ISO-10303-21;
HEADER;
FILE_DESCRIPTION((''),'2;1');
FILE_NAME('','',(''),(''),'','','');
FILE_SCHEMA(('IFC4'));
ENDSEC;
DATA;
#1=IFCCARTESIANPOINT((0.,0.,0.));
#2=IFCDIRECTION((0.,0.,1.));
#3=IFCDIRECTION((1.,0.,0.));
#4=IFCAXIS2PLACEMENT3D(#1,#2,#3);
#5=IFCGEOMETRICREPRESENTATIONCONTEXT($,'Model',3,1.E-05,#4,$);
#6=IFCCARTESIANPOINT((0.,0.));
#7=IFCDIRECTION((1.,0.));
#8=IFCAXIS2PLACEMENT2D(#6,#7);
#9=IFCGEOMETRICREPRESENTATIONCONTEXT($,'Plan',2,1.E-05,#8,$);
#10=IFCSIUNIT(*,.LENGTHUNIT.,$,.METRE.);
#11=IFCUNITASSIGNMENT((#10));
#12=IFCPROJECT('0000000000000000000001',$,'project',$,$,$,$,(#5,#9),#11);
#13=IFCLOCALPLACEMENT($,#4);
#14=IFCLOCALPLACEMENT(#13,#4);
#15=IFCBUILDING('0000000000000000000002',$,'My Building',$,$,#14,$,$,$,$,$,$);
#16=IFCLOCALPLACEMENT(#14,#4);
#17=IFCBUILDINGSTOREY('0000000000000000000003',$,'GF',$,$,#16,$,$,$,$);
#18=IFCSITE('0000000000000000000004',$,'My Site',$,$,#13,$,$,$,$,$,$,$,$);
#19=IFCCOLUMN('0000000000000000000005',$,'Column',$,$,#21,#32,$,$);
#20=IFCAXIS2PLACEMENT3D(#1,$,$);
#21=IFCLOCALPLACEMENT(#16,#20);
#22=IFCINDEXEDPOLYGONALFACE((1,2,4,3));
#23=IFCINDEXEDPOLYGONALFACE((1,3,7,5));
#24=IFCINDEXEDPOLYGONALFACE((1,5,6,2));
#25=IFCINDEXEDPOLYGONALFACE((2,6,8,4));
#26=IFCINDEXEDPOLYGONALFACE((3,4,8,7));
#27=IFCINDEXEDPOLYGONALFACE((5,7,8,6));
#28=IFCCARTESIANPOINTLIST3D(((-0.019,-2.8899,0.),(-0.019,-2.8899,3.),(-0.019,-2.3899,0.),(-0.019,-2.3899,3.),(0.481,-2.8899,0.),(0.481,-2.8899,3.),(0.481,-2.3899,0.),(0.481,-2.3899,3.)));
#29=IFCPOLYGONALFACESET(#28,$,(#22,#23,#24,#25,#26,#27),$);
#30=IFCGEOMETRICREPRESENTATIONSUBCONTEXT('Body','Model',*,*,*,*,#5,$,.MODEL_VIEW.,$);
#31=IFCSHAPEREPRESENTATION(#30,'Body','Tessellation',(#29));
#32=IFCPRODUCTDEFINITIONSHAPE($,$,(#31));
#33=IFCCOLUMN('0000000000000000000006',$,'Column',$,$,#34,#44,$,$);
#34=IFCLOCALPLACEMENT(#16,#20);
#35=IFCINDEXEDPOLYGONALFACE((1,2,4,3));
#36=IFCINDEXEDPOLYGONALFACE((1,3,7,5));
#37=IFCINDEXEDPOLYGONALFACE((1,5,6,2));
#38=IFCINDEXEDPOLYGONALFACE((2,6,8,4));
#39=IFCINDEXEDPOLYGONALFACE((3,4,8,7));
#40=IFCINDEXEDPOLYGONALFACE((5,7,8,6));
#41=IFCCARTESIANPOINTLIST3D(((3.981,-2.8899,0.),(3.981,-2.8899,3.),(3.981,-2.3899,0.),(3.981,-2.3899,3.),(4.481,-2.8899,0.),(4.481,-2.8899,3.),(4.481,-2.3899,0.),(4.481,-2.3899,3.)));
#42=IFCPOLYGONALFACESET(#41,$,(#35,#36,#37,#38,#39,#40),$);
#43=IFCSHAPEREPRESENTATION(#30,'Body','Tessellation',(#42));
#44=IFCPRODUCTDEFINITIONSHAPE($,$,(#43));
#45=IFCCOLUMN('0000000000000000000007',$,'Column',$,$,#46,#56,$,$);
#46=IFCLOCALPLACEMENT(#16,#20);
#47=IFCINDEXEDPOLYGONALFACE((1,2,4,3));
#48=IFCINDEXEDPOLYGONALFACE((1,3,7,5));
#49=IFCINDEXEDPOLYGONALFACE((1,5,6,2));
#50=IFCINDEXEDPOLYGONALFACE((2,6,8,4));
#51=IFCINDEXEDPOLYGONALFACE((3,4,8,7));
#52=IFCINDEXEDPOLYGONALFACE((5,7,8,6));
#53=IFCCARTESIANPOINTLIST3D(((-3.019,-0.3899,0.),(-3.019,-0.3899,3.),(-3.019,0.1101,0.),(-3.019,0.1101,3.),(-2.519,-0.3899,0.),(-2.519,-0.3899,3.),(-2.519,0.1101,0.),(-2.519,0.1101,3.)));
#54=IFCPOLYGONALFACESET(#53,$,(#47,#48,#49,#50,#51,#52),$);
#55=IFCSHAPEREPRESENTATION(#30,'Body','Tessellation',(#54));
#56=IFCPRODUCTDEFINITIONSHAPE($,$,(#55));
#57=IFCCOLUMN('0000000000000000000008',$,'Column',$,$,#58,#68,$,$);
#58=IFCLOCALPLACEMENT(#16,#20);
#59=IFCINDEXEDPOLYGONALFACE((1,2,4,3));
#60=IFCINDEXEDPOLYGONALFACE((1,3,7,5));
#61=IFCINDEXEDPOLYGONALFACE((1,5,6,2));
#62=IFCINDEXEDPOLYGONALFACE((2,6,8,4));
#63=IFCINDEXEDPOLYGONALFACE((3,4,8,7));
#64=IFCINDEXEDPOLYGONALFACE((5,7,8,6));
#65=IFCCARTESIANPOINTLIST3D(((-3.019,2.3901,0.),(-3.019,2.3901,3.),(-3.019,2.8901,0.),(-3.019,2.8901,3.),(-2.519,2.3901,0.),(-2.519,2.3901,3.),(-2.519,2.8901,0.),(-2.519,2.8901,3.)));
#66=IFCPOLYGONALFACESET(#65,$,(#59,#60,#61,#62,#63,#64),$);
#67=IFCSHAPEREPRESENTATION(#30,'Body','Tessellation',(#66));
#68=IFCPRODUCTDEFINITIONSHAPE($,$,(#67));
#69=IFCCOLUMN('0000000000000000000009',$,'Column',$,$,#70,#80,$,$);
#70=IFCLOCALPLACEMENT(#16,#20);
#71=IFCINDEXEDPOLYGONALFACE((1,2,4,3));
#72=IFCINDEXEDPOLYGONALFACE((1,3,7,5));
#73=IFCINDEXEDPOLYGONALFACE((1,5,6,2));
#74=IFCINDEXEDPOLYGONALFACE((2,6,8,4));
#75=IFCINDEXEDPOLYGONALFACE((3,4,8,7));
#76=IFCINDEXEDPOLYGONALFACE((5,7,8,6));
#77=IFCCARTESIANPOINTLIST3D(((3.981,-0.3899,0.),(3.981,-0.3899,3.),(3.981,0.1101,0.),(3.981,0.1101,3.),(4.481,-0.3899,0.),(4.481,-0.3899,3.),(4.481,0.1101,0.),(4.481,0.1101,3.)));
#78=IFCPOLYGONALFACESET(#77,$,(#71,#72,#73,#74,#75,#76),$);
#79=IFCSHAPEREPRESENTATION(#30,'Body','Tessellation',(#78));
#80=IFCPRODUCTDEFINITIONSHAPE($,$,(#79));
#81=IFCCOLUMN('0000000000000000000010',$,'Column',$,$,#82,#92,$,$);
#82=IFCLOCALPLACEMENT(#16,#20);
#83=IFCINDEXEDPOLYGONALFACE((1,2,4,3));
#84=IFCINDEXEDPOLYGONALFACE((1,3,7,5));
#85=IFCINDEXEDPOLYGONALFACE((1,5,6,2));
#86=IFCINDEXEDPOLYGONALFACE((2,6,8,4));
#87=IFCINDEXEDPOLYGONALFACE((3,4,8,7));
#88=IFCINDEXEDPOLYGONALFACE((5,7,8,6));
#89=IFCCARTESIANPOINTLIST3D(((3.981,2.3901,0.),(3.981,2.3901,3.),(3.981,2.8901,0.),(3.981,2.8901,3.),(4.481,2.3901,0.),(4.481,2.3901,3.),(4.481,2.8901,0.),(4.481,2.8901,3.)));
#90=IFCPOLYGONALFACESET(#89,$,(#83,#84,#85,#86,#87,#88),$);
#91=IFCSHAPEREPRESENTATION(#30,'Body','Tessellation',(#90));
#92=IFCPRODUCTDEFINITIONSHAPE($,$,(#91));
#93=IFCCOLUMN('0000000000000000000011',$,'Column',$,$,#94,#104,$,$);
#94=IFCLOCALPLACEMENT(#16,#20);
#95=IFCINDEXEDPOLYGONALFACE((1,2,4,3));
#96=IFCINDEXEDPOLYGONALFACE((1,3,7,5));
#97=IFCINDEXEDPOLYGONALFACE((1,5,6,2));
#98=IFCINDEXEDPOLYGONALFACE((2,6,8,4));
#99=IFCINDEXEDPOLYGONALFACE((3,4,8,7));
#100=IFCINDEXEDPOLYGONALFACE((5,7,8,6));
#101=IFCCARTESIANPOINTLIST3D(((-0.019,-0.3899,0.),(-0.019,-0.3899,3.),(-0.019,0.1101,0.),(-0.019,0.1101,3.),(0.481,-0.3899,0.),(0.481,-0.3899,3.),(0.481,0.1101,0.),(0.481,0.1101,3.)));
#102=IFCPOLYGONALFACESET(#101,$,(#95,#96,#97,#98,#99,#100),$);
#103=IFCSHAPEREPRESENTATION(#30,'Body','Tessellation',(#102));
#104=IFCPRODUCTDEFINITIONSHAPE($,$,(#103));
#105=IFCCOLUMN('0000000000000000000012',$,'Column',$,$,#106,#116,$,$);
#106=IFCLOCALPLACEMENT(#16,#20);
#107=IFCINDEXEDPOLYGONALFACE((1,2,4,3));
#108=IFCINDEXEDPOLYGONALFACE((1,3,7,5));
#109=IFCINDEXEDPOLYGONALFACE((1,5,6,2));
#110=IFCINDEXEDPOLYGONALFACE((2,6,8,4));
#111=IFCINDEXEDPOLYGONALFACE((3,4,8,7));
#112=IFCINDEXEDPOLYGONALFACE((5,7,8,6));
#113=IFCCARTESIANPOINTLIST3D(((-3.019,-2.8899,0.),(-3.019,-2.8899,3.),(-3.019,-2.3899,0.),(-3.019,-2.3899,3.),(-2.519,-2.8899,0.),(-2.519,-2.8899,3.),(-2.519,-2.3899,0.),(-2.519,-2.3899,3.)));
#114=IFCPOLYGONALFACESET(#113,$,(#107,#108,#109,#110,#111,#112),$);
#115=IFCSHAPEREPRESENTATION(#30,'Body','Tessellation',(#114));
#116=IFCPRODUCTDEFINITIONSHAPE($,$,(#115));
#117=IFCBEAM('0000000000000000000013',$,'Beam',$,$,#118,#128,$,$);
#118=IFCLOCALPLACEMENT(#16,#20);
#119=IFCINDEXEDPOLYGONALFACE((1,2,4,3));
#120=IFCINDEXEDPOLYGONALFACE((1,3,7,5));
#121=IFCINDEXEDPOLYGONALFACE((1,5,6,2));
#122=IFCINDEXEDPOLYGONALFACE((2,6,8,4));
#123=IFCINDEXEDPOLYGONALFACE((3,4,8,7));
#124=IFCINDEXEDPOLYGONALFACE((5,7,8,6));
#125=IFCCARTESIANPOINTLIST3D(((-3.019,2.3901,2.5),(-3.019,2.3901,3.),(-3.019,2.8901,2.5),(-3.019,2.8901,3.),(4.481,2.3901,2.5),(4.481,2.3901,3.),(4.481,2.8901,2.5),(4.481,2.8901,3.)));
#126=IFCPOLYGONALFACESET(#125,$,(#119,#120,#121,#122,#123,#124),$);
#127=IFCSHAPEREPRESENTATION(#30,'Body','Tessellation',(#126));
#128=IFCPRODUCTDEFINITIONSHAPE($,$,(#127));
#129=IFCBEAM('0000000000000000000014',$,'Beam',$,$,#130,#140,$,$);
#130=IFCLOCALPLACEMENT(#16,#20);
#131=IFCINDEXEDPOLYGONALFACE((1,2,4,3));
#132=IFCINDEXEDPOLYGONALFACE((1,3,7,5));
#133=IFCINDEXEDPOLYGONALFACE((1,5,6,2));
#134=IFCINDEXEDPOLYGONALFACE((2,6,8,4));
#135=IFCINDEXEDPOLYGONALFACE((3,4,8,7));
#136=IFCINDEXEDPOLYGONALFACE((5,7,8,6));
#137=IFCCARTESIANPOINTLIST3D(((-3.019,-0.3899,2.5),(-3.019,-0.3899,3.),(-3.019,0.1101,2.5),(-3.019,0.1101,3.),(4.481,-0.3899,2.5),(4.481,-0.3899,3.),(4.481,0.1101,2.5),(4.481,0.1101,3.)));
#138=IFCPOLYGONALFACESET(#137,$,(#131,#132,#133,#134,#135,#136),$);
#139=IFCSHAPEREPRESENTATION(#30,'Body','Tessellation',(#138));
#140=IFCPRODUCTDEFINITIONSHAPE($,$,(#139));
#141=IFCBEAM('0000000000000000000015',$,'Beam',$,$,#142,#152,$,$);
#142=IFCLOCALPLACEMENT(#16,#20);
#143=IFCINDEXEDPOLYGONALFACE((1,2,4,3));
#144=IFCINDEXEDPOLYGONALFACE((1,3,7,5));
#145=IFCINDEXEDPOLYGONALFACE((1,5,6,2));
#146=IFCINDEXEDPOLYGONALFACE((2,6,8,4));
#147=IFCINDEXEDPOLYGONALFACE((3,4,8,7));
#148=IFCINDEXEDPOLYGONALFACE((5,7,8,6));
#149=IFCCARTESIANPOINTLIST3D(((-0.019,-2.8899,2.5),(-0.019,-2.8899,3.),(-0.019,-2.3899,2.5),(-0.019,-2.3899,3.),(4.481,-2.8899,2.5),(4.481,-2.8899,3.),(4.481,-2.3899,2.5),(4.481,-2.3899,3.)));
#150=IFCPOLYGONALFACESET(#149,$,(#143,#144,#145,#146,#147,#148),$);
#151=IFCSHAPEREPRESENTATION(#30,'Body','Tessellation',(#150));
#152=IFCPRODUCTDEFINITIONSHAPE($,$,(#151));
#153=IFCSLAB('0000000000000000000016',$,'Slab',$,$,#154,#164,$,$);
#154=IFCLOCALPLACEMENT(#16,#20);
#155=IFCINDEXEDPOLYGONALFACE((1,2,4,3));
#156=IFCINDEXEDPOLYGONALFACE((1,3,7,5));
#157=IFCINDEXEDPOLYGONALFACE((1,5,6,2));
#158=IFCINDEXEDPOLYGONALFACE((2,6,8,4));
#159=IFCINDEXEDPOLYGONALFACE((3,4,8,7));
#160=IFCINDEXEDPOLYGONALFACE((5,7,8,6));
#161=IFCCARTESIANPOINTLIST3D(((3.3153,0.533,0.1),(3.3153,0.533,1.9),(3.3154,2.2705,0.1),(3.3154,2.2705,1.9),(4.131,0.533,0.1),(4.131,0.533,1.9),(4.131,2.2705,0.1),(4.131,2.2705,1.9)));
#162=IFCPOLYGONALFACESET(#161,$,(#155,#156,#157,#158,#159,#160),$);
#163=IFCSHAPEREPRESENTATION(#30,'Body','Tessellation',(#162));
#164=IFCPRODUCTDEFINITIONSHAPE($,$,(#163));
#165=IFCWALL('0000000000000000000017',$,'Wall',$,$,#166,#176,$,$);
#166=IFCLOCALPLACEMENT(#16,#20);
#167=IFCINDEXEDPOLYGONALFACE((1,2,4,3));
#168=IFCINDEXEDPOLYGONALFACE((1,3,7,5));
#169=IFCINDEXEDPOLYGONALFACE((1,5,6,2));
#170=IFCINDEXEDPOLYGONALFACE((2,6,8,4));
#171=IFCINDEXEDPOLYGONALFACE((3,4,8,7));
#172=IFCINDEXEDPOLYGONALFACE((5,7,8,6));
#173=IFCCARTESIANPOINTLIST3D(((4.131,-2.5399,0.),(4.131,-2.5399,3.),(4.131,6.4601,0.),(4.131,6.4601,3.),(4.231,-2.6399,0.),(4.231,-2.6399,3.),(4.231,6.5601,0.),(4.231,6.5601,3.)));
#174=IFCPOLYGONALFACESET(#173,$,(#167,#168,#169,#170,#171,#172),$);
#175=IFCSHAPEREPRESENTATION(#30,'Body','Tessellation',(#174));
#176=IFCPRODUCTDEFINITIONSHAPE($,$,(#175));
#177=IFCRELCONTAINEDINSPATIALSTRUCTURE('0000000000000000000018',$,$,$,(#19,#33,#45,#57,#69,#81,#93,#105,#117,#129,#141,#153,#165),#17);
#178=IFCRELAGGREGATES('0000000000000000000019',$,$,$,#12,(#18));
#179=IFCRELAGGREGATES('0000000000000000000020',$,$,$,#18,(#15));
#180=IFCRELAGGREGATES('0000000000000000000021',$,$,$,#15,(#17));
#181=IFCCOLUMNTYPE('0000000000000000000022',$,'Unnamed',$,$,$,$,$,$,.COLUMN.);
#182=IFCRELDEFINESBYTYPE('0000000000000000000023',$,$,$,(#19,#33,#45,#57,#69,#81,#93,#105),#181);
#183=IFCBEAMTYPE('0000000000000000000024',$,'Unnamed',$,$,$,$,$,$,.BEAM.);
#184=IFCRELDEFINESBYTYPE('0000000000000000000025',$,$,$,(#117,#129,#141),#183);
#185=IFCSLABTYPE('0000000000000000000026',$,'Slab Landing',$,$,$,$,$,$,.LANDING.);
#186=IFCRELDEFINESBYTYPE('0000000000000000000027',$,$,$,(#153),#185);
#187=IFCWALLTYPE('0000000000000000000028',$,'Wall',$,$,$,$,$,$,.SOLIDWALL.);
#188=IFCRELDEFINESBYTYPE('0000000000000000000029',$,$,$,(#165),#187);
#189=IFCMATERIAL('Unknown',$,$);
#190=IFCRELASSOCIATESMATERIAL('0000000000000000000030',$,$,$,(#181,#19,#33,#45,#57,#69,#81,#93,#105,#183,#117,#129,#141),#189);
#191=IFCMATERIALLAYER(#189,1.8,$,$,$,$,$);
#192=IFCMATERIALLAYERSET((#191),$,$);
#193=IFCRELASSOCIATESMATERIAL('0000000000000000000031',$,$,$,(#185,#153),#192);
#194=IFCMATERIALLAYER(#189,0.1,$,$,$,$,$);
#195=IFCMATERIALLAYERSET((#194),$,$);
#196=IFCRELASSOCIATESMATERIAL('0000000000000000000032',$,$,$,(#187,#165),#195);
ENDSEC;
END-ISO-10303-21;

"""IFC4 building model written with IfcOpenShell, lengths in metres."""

from ifc_helpers import new_model, si_unit, frame, origin_with_axes, origin_2d_with_axis, place, context, subcontext, project, spatial, line, indexed_curve, rectangle, outline, extrude, material, layer, layer_set, layer_usage, material_profile, profile_set, profile_usage, type_object, element, save


model = new_model("IFC4")

# Units and contexts
model_context = context("Model", 3, precision=1e-05, world=origin_with_axes())
plan_context = context("Plan", 2, precision=1e-05, world=origin_2d_with_axis())
body_context_1 = subcontext(model_context, "Body", "Model", "MODEL_VIEW")
ifc_project = project(units=[si_unit("LENGTHUNIT", "METRE")], contexts=[model_context, plan_context])

# Site, building, storey
site_placement = place(None, origin_with_axes())
site = spatial("IfcSite", under=ifc_project, at=site_placement, Name="My Site")
building_placement = place(site_placement, origin_with_axes())
building = spatial("IfcBuilding", under=site, at=building_placement, Name="My Building")
storey_placement = place(building_placement, origin_with_axes())
storey = spatial("IfcBuildingStorey", under=building, at=storey_placement, Name="GF")

# Columns
ifc_material = material(Name="Unknown")
ifc_material_profile_1 = material_profile(ifc_material, rectangle(XDim=0.5, YDim=0.5))
ifc_profile_set_1 = profile_set([ifc_material_profile_1])
ifc_profile_usage_1 = profile_usage(ifc_profile_set_1, cardinal=5)
column_type = type_object("IfcColumnType", Name="Unnamed", PredefinedType="COLUMN", material=ifc_profile_set_1)
column_1_placement = place(storey_placement, frame((0.231, -2.6399, 0.0), z_axis=(0.0, 0.0, 1.0), x_axis=(1.0, 0.0, 0.0)))
element("IfcColumn", 1, at=column_1_placement, inside=storey, type_object=column_type, material=ifc_profile_usage_1, Name="Column", context=body_context_1, shape_type="SweptSolid", body=[
    extrude(rectangle(XDim=0.5, YDim=0.5), origin_with_axes(), (0.0, 0.0, 1.0), 3.0),
])
ifc_profile_usage_2 = profile_usage(ifc_profile_set_1, cardinal=5)
column_2_placement = place(storey_placement, frame((4.231, -2.6399, 0.0), z_axis=(0.0, 0.0, 1.0), x_axis=(1.0, 0.0, 0.0)))
element("IfcColumn", 2, at=column_2_placement, inside=storey, type_object=column_type, material=ifc_profile_usage_2, Name="Column", context=body_context_1, shape_type="SweptSolid", body=[
    extrude(rectangle(XDim=0.5, YDim=0.5), origin_with_axes(), (0.0, 0.0, 1.0), 3.0),
])
ifc_profile_usage_3 = profile_usage(ifc_profile_set_1, cardinal=5)
column_3_placement = place(storey_placement, frame((-2.769, -0.1399, 0.0), z_axis=(0.0, 0.0, 1.0), x_axis=(1.0, 0.0, 0.0)))
element("IfcColumn", 3, at=column_3_placement, inside=storey, type_object=column_type, material=ifc_profile_usage_3, Name="Column", context=body_context_1, shape_type="SweptSolid", body=[
    extrude(rectangle(XDim=0.5, YDim=0.5), origin_with_axes(), (0.0, 0.0, 1.0), 3.0),
])
ifc_profile_usage_4 = profile_usage(ifc_profile_set_1, cardinal=5)
column_4_placement = place(storey_placement, frame((-2.769, 2.6401, 0.0), z_axis=(0.0, 0.0, 1.0), x_axis=(1.0, 0.0, 0.0)))
element("IfcColumn", 4, at=column_4_placement, inside=storey, type_object=column_type, material=ifc_profile_usage_4, Name="Column", context=body_context_1, shape_type="SweptSolid", body=[
    extrude(rectangle(XDim=0.5, YDim=0.5), origin_with_axes(), (0.0, 0.0, 1.0), 3.0),
])
ifc_profile_usage_5 = profile_usage(ifc_profile_set_1, cardinal=5)
column_5_placement = place(storey_placement, frame((4.231, -0.1399, 0.0), z_axis=(0.0, 0.0, 1.0), x_axis=(1.0, 0.0, 0.0)))
element("IfcColumn", 5, at=column_5_placement, inside=storey, type_object=column_type, material=ifc_profile_usage_5, Name="Column", context=body_context_1, shape_type="SweptSolid", body=[
    extrude(rectangle(XDim=0.5, YDim=0.5), origin_with_axes(), (0.0, 0.0, 1.0), 3.0),
])
ifc_profile_usage_6 = profile_usage(ifc_profile_set_1, cardinal=5)
column_6_placement = place(storey_placement, frame((4.231, 2.6401, 0.0), z_axis=(0.0, 0.0, 1.0), x_axis=(1.0, 0.0, 0.0)))
element("IfcColumn", 6, at=column_6_placement, inside=storey, type_object=column_type, material=ifc_profile_usage_6, Name="Column", context=body_context_1, shape_type="SweptSolid", body=[
    extrude(rectangle(XDim=0.5, YDim=0.5), origin_with_axes(), (0.0, 0.0, 1.0), 3.0),
])
ifc_profile_usage_7 = profile_usage(ifc_profile_set_1, cardinal=5)
column_7_placement = place(storey_placement, frame((0.231, -0.1399, 0.0), z_axis=(0.0, 0.0, 1.0), x_axis=(1.0, 0.0, 0.0)))
element("IfcColumn", 7, at=column_7_placement, inside=storey, type_object=column_type, material=ifc_profile_usage_7, Name="Column", context=body_context_1, shape_type="SweptSolid", body=[
    extrude(rectangle(XDim=0.5, YDim=0.5), origin_with_axes(), (0.0, 0.0, 1.0), 3.0),
])
ifc_profile_usage_8 = profile_usage(ifc_profile_set_1, cardinal=5)
column_8_placement = place(storey_placement, frame((-2.769, -2.6399, 0.0), z_axis=(0.0, 0.0, 1.0), x_axis=(1.0, 0.0, 0.0)))
element("IfcColumn", 8, at=column_8_placement, inside=storey, type_object=column_type, material=ifc_profile_usage_8, Name="Column", context=body_context_1, shape_type="SweptSolid", body=[
    extrude(rectangle(XDim=0.5, YDim=0.5), origin_with_axes(), (0.0, 0.0, 1.0), 3.0),
])

# Beams
ifc_material_profile_2 = material_profile(ifc_material, rectangle(XDim=0.5, YDim=0.5))
ifc_profile_set_2 = profile_set([ifc_material_profile_2])
ifc_profile_usage_9 = profile_usage(ifc_profile_set_2, cardinal=7)
beam_type = type_object("IfcBeamType", Name="Unnamed", PredefinedType="BEAM", material=ifc_profile_set_2)
beam_1_placement = place(storey_placement, frame((4.481, 2.3901, 3.0), z_axis=(-1.0, 0.0, 0.0), x_axis=(0.0, -1.0, 0.0)))
element("IfcBeam", 9, at=beam_1_placement, inside=storey, type_object=beam_type, material=ifc_profile_usage_9, Name="Beam", context=body_context_1, shape_type="SweptSolid", body=[
    extrude(rectangle(XDim=0.5, YDim=0.5), frame((-0.25, -0.25, 0.0), z_axis=(0.0, 0.0, 1.0), x_axis=(1.0, 0.0, 0.0)), (0.0, 0.0, 1.0), 7.5),
])
ifc_profile_usage_10 = profile_usage(ifc_profile_set_2, cardinal=7)
beam_2_placement = place(storey_placement, frame((4.481, -0.3899, 3.0), z_axis=(-1.0, 0.0, 0.0), x_axis=(0.0, -1.0, 0.0)))
element("IfcBeam", 10, at=beam_2_placement, inside=storey, type_object=beam_type, material=ifc_profile_usage_10, Name="Beam", context=body_context_1, shape_type="SweptSolid", body=[
    extrude(rectangle(XDim=0.5, YDim=0.5), frame((-0.25, -0.25, 0.0), z_axis=(0.0, 0.0, 1.0), x_axis=(1.0, 0.0, 0.0)), (0.0, 0.0, 1.0), 7.5),
])
ifc_profile_usage_11 = profile_usage(ifc_profile_set_2, cardinal=7)
beam_3_placement = place(storey_placement, frame((4.481, -2.8899, 3.0), z_axis=(-1.0, -0.000001, 0.000001), x_axis=(0.000001, -1.0, 0.0)))
element("IfcBeam", 11, at=beam_3_placement, inside=storey, type_object=beam_type, material=ifc_profile_usage_11, Name="Beam", context=body_context_1, shape_type="SweptSolid", body=[
    extrude(rectangle(XDim=0.5, YDim=0.5), frame((-0.25, -0.25, 0.0), z_axis=(0.0, 0.0, 1.0), x_axis=(1.0, 0.0, 0.0)), (0.0, 0.0, 1.0), 4.5),
])

# Slab
ifc_layer_1 = layer(ifc_material, 1.8)
ifc_layer_set_1 = layer_set([ifc_layer_1])
ifc_layer_usage_1 = layer_usage(ifc_layer_set_1, "AXIS3", "POSITIVE", -0.1)
slab_type_1 = type_object("IfcSlabType", Name="Slab Landing", PredefinedType="LANDING", material=ifc_layer_set_1)
slab_1_placement = place(storey_placement, frame((3.3153, 0.533, 0.2), z_axis=(0.0, 0.0, 1.0), x_axis=(1.0, 0.0, 0.0)))
element("IfcSlab", 12, at=slab_1_placement, inside=storey, type_object=slab_type_1, material=ifc_layer_usage_1, Name="Slab", context=body_context_1, shape_type="SweptSolid", body=[
    extrude(outline(indexed_curve([(0.0, 1.7375), (0.8156, 1.7375), (0.8156, 0.0), (0.0, 0.0), (0.0, 1.7375)])), frame((0.0, 0.0, -0.1), z_axis=(0.0, 0.0, 1.0), x_axis=(1.0, 0.0, 0.0)), (0.0, 0.0, 1.0), 1.8),
])

# Shared definitions
ifc_layer_2 = layer(ifc_material, 0.1)
ifc_layer_set_2 = layer_set([ifc_layer_2])
wall_type = type_object("IfcWallType", Name="Wall", PredefinedType="SOLIDWALL", material=ifc_layer_set_2)

# Wall
ifc_layer_usage_2 = layer_usage(ifc_layer_set_2, "AXIS2", "POSITIVE", 0.0)
wall_1_placement = place(storey_placement, frame((4.231, -2.6399, 0.0), z_axis=(0.0, 0.0, 1.0), x_axis=(0.0, 1.0, 0.0)))
element("IfcWall", 13, at=wall_1_placement, inside=storey, type_object=wall_type, material=ifc_layer_usage_2, Name="Wall", context=body_context_1, shape_type="SweptSolid", body=[
    extrude(outline(indexed_curve([(0.0, 0.0), (0.1, 0.1), (9.1, 0.1), (9.2, 0.0)], segments=[line(1, 2, 3, 4, 1)])), origin_with_axes(), (0.0, 0.0, 1.0), 3.0),
])

save(model, "model.ifc")
